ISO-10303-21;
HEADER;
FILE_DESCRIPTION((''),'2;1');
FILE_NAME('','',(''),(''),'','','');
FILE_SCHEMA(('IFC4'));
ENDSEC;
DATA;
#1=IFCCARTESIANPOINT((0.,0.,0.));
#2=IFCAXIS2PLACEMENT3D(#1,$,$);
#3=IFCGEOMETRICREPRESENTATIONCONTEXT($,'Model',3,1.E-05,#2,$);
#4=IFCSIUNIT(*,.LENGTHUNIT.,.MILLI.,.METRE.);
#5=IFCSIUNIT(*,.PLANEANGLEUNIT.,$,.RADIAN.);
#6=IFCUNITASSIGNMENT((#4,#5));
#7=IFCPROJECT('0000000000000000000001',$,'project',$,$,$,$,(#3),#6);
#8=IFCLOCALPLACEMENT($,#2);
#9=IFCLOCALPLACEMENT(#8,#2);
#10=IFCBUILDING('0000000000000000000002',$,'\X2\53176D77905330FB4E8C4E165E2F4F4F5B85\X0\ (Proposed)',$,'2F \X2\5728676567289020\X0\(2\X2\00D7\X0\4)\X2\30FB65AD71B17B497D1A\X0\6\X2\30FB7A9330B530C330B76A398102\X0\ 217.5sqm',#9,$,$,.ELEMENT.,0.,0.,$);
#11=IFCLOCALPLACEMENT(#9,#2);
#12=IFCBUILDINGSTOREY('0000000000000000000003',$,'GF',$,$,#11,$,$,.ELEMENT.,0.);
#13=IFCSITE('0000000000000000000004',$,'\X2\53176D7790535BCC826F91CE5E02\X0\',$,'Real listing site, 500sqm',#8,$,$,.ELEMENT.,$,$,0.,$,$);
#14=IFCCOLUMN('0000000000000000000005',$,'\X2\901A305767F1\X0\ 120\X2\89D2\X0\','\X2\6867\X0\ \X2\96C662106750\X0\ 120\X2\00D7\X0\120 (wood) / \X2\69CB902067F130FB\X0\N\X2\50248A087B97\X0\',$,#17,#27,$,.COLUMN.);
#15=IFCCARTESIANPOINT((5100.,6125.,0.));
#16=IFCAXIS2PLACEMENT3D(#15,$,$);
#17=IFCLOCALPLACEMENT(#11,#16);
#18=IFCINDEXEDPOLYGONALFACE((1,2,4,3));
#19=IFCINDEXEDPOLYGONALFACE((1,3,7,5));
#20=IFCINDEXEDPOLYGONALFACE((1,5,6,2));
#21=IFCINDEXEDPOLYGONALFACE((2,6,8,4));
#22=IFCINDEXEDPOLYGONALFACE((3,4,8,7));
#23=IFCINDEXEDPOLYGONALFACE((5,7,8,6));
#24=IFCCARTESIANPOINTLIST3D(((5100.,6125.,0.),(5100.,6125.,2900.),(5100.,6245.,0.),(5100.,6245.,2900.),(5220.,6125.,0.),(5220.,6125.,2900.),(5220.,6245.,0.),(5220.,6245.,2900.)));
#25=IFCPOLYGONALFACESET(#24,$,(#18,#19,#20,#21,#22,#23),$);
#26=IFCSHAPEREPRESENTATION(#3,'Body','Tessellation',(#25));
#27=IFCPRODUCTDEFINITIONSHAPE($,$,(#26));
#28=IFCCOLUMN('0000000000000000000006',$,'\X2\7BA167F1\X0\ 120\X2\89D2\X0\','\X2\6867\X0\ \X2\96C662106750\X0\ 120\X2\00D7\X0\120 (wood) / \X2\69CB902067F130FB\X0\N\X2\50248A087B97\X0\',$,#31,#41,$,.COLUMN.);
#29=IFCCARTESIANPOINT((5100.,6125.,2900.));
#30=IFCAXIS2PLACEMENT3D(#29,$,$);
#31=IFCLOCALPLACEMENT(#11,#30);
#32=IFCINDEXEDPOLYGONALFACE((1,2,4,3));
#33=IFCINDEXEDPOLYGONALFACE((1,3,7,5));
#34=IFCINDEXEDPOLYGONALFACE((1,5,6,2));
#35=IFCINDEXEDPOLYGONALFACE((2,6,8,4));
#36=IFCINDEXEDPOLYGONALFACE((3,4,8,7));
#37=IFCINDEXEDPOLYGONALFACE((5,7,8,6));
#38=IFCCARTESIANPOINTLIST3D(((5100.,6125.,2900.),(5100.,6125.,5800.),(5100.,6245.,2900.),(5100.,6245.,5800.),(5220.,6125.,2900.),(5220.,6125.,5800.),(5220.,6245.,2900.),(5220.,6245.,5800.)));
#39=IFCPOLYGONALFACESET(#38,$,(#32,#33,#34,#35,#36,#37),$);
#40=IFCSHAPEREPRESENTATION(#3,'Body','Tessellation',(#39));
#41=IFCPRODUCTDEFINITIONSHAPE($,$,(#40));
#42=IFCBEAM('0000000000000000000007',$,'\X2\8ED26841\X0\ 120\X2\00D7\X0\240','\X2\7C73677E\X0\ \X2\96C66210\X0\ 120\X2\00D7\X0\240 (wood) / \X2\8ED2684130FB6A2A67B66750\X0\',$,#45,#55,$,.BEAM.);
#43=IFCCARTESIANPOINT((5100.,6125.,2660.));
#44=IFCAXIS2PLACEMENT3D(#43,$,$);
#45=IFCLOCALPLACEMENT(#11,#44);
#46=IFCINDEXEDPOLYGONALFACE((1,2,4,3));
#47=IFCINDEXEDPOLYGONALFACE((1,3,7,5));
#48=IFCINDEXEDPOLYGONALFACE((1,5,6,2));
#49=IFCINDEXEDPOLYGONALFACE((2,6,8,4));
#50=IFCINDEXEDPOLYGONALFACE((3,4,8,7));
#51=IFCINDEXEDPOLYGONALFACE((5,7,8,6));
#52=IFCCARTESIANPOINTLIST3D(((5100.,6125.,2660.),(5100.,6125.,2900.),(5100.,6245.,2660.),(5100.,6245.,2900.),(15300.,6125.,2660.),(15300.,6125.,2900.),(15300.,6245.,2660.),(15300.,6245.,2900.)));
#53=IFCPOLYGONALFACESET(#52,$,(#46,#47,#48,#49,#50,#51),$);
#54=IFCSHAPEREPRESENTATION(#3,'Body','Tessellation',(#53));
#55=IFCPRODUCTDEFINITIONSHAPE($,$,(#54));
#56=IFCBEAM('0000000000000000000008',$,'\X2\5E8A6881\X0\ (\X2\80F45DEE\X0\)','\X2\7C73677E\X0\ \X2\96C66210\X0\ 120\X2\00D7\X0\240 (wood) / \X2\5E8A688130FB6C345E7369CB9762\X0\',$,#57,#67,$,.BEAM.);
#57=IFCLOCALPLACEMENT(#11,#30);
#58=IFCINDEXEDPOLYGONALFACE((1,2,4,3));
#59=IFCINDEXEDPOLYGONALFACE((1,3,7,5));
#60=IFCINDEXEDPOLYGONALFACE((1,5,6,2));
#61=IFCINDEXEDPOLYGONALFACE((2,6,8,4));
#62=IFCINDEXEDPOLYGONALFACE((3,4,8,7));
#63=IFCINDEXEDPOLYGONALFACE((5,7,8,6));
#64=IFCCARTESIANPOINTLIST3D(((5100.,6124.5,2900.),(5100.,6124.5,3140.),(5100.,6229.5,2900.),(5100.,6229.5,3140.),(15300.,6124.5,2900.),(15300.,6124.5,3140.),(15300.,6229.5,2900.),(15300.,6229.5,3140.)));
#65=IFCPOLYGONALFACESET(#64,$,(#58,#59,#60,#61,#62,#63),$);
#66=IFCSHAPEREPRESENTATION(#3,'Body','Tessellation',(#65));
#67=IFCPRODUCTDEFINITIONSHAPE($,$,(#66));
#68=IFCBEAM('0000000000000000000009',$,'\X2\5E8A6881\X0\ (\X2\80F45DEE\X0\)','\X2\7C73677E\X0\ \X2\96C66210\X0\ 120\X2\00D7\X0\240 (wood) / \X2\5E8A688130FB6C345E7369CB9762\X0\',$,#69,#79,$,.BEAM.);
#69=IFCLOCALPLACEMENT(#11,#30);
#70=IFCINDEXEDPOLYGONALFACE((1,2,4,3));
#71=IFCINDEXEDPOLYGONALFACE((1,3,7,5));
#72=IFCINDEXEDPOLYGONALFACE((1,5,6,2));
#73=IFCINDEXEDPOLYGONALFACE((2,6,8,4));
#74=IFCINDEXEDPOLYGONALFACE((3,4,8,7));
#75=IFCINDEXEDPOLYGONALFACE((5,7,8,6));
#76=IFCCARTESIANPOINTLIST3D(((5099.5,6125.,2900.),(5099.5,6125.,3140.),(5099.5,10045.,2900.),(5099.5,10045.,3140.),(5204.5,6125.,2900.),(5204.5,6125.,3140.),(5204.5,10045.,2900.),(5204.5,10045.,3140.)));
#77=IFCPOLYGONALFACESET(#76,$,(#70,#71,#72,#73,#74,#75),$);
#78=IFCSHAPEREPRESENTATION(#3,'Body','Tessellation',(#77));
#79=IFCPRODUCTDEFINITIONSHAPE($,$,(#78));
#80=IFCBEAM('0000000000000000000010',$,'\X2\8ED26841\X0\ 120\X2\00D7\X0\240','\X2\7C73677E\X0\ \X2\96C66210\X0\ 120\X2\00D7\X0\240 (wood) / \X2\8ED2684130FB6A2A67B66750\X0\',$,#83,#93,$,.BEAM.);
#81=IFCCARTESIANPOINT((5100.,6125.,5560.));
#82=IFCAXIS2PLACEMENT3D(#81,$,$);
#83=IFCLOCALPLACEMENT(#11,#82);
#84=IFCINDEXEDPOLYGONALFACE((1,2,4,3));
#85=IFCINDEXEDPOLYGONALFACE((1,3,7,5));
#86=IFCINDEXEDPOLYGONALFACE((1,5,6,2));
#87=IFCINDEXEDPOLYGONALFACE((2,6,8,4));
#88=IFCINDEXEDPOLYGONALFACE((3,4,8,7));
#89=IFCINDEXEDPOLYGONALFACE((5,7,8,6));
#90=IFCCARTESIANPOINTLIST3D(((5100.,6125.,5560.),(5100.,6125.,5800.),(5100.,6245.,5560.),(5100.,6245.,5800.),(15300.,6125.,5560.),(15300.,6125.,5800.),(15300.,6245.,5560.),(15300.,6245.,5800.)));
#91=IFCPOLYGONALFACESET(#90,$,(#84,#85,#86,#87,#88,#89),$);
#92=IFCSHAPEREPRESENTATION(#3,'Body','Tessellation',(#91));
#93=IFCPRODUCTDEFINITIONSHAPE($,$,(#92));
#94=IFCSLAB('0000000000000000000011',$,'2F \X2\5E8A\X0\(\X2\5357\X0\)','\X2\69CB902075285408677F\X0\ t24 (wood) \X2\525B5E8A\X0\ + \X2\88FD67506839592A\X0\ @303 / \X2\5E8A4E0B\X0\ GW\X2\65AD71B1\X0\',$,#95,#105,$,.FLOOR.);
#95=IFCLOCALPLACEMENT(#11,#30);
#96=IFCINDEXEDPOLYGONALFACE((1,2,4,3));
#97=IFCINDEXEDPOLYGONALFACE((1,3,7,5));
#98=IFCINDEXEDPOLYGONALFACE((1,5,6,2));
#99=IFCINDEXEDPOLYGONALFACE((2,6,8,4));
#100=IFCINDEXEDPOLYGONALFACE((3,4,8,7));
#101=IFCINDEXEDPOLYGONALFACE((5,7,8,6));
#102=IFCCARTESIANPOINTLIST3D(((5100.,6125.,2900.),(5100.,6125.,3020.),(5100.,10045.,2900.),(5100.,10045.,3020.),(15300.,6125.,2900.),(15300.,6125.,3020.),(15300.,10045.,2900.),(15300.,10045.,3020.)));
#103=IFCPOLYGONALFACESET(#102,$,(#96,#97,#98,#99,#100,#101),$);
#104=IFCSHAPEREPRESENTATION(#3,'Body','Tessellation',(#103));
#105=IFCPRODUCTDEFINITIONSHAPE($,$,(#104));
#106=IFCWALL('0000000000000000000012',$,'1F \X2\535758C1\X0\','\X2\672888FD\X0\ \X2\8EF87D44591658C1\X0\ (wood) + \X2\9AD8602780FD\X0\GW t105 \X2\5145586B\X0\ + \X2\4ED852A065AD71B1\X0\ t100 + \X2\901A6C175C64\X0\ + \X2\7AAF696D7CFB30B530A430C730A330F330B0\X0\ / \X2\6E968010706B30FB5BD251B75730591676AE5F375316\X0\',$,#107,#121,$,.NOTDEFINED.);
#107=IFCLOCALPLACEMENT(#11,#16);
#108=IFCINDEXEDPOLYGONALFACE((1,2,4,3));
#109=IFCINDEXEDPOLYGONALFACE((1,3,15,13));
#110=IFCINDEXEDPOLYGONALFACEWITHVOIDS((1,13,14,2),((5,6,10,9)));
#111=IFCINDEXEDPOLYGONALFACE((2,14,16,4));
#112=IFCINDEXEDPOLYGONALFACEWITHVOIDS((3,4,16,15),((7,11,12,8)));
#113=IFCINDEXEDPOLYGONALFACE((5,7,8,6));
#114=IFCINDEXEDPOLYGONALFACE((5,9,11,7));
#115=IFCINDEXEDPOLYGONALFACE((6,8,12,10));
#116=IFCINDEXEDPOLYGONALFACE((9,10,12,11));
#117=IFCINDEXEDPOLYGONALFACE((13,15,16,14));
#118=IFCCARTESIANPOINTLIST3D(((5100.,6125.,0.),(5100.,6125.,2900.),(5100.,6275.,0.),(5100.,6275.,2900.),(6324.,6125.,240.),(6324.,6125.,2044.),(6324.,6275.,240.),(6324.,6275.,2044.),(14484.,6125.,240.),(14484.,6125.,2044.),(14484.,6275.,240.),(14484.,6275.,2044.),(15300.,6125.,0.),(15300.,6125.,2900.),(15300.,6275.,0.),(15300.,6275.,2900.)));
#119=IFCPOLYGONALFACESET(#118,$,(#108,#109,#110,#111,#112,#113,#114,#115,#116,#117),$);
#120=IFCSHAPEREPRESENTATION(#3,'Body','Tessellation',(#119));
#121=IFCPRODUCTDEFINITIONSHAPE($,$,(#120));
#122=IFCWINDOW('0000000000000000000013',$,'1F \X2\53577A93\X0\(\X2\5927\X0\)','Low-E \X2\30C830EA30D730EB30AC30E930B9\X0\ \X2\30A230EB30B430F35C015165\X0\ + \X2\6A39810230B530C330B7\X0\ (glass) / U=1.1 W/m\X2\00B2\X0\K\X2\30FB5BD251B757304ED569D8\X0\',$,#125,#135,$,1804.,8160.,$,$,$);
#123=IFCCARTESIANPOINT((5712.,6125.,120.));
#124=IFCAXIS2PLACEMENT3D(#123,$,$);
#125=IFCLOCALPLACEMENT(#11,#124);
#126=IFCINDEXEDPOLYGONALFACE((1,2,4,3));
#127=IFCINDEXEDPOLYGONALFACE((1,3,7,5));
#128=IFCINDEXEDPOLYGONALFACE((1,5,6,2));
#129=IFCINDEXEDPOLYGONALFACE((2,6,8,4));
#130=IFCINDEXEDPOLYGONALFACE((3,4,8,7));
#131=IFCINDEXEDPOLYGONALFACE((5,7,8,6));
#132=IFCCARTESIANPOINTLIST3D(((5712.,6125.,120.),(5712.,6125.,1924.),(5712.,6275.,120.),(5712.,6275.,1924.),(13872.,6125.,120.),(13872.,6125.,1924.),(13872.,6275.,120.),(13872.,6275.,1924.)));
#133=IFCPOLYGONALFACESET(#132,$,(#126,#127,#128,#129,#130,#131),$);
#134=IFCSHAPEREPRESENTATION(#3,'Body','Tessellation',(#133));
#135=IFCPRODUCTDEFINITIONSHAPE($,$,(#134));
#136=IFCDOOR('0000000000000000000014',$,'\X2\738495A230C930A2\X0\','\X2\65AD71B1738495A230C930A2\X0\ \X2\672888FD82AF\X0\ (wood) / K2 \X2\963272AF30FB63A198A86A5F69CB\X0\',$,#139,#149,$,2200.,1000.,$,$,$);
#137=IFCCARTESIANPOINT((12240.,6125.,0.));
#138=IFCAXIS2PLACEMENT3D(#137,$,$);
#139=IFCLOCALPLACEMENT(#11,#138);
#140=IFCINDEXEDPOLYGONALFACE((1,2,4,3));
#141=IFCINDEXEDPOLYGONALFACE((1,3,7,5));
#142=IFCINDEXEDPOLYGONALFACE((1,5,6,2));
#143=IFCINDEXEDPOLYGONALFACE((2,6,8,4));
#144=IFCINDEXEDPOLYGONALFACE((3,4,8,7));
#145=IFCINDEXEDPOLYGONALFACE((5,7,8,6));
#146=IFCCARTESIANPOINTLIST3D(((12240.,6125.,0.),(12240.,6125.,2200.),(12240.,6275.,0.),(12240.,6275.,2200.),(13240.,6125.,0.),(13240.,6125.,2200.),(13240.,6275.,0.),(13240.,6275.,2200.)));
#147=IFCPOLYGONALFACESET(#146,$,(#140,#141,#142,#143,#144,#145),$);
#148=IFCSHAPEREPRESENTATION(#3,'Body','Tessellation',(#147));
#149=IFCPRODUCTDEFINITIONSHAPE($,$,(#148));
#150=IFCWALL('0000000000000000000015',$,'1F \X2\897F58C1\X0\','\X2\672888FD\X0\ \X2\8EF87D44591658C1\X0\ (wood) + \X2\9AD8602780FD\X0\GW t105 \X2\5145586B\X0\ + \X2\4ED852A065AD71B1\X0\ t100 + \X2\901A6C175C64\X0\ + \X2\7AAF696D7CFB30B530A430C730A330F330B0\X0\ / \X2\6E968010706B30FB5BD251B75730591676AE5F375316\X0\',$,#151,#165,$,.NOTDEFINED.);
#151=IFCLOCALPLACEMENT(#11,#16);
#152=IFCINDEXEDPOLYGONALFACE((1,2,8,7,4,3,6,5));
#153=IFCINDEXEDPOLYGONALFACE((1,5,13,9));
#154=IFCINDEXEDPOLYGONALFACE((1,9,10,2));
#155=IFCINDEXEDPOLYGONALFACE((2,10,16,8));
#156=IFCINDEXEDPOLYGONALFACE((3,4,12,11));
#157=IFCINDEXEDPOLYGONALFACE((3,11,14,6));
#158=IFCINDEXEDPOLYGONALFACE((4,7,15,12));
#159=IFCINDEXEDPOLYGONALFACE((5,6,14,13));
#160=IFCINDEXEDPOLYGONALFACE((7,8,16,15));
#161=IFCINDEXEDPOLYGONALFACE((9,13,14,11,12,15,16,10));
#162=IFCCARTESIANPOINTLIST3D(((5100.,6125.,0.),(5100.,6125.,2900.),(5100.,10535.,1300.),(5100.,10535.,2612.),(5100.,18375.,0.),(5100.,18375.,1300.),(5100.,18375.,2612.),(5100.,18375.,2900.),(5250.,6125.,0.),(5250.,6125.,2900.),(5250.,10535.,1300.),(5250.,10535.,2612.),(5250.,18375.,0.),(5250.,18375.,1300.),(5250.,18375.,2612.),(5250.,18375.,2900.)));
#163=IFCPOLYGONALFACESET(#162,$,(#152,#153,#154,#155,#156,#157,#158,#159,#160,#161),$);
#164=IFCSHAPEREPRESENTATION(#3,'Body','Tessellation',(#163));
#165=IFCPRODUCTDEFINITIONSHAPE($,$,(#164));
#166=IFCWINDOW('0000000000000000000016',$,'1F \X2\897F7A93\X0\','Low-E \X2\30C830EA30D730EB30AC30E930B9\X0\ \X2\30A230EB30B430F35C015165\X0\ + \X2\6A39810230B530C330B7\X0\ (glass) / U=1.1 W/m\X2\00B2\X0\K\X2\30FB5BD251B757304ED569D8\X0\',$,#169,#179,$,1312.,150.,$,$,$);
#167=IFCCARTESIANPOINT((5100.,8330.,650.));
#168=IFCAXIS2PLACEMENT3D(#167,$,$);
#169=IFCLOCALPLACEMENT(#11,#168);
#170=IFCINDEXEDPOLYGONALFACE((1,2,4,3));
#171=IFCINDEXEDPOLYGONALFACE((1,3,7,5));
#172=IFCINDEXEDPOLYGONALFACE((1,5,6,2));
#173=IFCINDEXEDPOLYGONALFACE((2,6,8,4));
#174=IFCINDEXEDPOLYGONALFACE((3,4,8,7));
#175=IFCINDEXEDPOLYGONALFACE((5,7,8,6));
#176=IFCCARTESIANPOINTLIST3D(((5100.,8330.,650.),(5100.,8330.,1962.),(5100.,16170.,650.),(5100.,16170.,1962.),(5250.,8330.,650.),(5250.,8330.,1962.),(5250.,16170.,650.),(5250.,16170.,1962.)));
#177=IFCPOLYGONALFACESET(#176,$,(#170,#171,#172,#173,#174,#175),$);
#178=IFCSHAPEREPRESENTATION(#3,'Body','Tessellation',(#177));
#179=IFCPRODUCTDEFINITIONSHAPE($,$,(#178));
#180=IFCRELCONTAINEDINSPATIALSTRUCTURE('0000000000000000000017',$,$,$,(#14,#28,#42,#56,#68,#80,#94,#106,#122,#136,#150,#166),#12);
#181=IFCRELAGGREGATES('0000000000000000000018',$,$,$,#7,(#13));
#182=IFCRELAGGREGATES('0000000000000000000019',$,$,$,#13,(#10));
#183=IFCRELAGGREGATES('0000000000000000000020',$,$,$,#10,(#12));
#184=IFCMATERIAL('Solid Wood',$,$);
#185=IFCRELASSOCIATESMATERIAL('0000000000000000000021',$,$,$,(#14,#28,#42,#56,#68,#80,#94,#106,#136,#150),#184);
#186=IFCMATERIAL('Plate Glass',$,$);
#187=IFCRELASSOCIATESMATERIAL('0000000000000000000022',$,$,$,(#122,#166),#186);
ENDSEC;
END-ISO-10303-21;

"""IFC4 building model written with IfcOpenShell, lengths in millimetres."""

from ifc_helpers import new_model, si_unit, frame, frame_2d, origin, place, context, project, spatial, rectangle, extrude, material, element, fill, save


model = new_model("IFC4")

# Units and contexts
model_context = context("Model", 3, precision=1e-05, world=origin())
ifc_project = project(units=[si_unit("LENGTHUNIT", "METRE", prefix="MILLI"), si_unit("PLANEANGLEUNIT", "RADIAN")], contexts=[model_context])

# Site, building, storey
site_placement = place(None, origin())
site = spatial("IfcSite", under=ifc_project, at=site_placement, Name="北海道富良野市", ObjectType="Real listing site, 500sqm", CompositionType="ELEMENT", RefElevation=0.0)
building_placement = place(site_placement, origin())
building = spatial("IfcBuilding", under=site, at=building_placement, Name="北海道・二世帯住宅 (Proposed)", ObjectType="2F 在来木造(2×4)・断熱等級6・窓サッシ樹脂 217.5sqm", CompositionType="ELEMENT", ElevationOfRefHeight=0.0, ElevationOfTerrain=0.0)
storey_placement = place(building_placement, origin())
storey = spatial("IfcBuildingStorey", under=building, at=storey_placement, Name="GF", CompositionType="ELEMENT", Elevation=0.0)

# Columns
ifc_material_1 = material(Name="Solid Wood")
column_1_placement = place(storey_placement, frame((5100.0, 6125.0, 0.0)))
element("IfcColumn", 1, at=column_1_placement, inside=storey, material=ifc_material_1, Name="通し柱 120角", Description="桧 集成材 120×120 (wood) / 構造柱・N値計算", PredefinedType="COLUMN", context=model_context, shape_type="SweptSolid", body=[
    extrude(rectangle(XDim=120.0, YDim=120.0, at=frame_2d((60.0, 60.0))), frame((5100.0, 6125.0, 0.0)), (0.0, 0.0, 1.0), 2900.0),
])
column_2_placement = place(storey_placement, frame((5100.0, 6125.0, 2900.0)))
element("IfcColumn", 2, at=column_2_placement, inside=storey, material=ifc_material_1, Name="管柱 120角", Description="桧 集成材 120×120 (wood) / 構造柱・N値計算", PredefinedType="COLUMN", context=model_context, shape_type="SweptSolid", body=[
    extrude(rectangle(XDim=120.0, YDim=120.0, at=frame_2d((60.0, 60.0))), frame((5100.0, 6125.0, 2900.0)), (0.0, 0.0, 1.0), 2900.0),
])

# Beams
beam_1_placement = place(storey_placement, frame((5100.0, 6125.0, 2660.0)))
element("IfcBeam", 3, at=beam_1_placement, inside=storey, material=ifc_material_1, Name="軒桁 120×240", Description="米松 集成 120×240 (wood) / 軒桁・横架材", PredefinedType="BEAM", context=model_context, shape_type="SweptSolid", body=[
    extrude(rectangle(XDim=10200.0, YDim=120.0, at=frame_2d((5100.0, 60.0))), frame((5100.0, 6125.0, 2660.0)), (0.0, 0.0, 1.0), 240.0),
])
beam_2_placement = place(storey_placement, frame((5100.0, 6125.0, 2900.0)))
element("IfcBeam", 4, at=beam_2_placement, inside=storey, material=ifc_material_1, Name="床梁 (胴差)", Description="米松 集成 120×240 (wood) / 床梁・水平構面", PredefinedType="BEAM", context=model_context, shape_type="SweptSolid", body=[
    extrude(rectangle(XDim=10200.0, YDim=105.0, at=frame_2d((5100.0, 52.0))), frame((5100.0, 6125.0, 2900.0)), (0.0, 0.0, 1.0), 240.0),
])
beam_3_placement = place(storey_placement, frame((5100.0, 6125.0, 2900.0)))
element("IfcBeam", 5, at=beam_3_placement, inside=storey, material=ifc_material_1, Name="床梁 (胴差)", Description="米松 集成 120×240 (wood) / 床梁・水平構面", PredefinedType="BEAM", context=model_context, shape_type="SweptSolid", body=[
    extrude(rectangle(XDim=105.0, YDim=3920.0, at=frame_2d((52.0, 1960.0))), frame((5100.0, 6125.0, 2900.0)), (0.0, 0.0, 1.0), 240.0),
])
beam_4_placement = place(storey_placement, frame((5100.0, 6125.0, 5560.0)))
element("IfcBeam", 6, at=beam_4_placement, inside=storey, material=ifc_material_1, Name="軒桁 120×240", Description="米松 集成 120×240 (wood) / 軒桁・横架材", PredefinedType="BEAM", context=model_context, shape_type="SweptSolid", body=[
    extrude(rectangle(XDim=10200.0, YDim=120.0, at=frame_2d((5100.0, 60.0))), frame((5100.0, 6125.0, 5560.0)), (0.0, 0.0, 1.0), 240.0),
])

# Slab
slab_1_placement = place(storey_placement, frame((5100.0, 6125.0, 2900.0)))
element("IfcSlab", 7, at=slab_1_placement, inside=storey, material=ifc_material_1, Name="2F 床(南)", Description="構造用合板 t24 (wood) 剛床 + 製材根太 @303 / 床下 GW断熱", PredefinedType="FLOOR", context=model_context, shape_type="SweptSolid", body=[
    extrude(rectangle(XDim=10200.0, YDim=3920.0, at=frame_2d((5100.0, 1960.0))), frame((5100.0, 6125.0, 2900.0)), (0.0, 0.0, 1.0), 120.0),
])

# Wall, openings, window, door
wall_1_placement = place(storey_placement, frame((5100.0, 6125.0, 0.0)))
wall_1 = element("IfcWall", 8, at=wall_1_placement, inside=storey, material=ifc_material_1, Name="1F 南壁", Description="木製 軸組外壁 (wood) + 高性能GW t105 充填 + 付加断熱 t100 + 通気層 + 窯業系サイディング / 準耐火・寒冷地外皮強化", PredefinedType="NOTDEFINED", context=model_context, shape_type="SweptSolid", body=[
    extrude(rectangle(XDim=10200.0, YDim=150.0, at=frame_2d((5100.0, 75.0))), frame((5100.0, 6125.0, 0.0)), (0.0, 0.0, 1.0), 2900.0),
])
opening_1_placement = place(storey_placement, frame((5712.0, 6125.0, 120.0)))
opening_1 = element("IfcOpeningElement", 9, at=opening_1_placement, cuts=wall_1, PredefinedType="NOTDEFINED", context=model_context, shape_type="SweptSolid", body=[
    extrude(rectangle(XDim=8160.0, YDim=150.0, at=frame_2d((4080.0, 75.0))), frame((5712.0, 6125.0, 120.0)), (0.0, 0.0, 1.0), 1804.0),
])
opening_2_placement = place(storey_placement, frame((12240.0, 6125.0, 0.0)))
opening_2 = element("IfcOpeningElement", 10, at=opening_2_placement, cuts=wall_1, PredefinedType="NOTDEFINED", context=model_context, shape_type="SweptSolid", body=[
    extrude(rectangle(XDim=1000.0, YDim=150.0, at=frame_2d((500.0, 75.0))), frame((12240.0, 6125.0, 0.0)), (0.0, 0.0, 1.0), 2200.0),
])
ifc_material_2 = material(Name="Plate Glass")
window_1_placement = place(storey_placement, frame((5712.0, 6125.0, 120.0)))
window_1 = element("IfcWindow", 11, at=window_1_placement, inside=storey, material=ifc_material_2, Name="1F 南窓(大)", Description="Low-E トリプルガラス アルゴン封入 + 樹脂サッシ (glass) / U=1.1 W/m²K・寒冷地仕様", OverallHeight=1804.0, OverallWidth=8160.0, context=model_context, shape_type="SweptSolid", body=[
    extrude(rectangle(XDim=8160.0, YDim=150.0, at=frame_2d((4080.0, 75.0))), frame((5712.0, 6125.0, 120.0)), (0.0, 0.0, 1.0), 1804.0),
])
fill(opening_1, window_1)
door_placement = place(storey_placement, frame((12240.0, 6125.0, 0.0)))
door = element("IfcDoor", 12, at=door_placement, inside=storey, material=ifc_material_1, Name="玄関ドア", Description="断熱玄関ドア 木製芯 (wood) / K2 防犯・採風機構", OverallHeight=2200.0, OverallWidth=1000.0, context=model_context, shape_type="SweptSolid", body=[
    extrude(rectangle(XDim=1000.0, YDim=150.0, at=frame_2d((500.0, 75.0))), frame((12240.0, 6125.0, 0.0)), (0.0, 0.0, 1.0), 2200.0),
])
fill(opening_2, door)

# Wall, opening, window
wall_2_placement = place(storey_placement, frame((5100.0, 6125.0, 0.0)))
wall_2 = element("IfcWall", 13, at=wall_2_placement, inside=storey, material=ifc_material_1, Name="1F 西壁", Description="木製 軸組外壁 (wood) + 高性能GW t105 充填 + 付加断熱 t100 + 通気層 + 窯業系サイディング / 準耐火・寒冷地外皮強化", PredefinedType="NOTDEFINED", context=model_context, shape_type="SweptSolid", body=[
    extrude(rectangle(XDim=150.0, YDim=12250.0, at=frame_2d((75.0, 6125.0))), frame((5100.0, 6125.0, 0.0)), (0.0, 0.0, 1.0), 2900.0),
])
opening_3_placement = place(storey_placement, frame((5100.0, 8330.0, 650.0)))
opening_3 = element("IfcOpeningElement", 14, at=opening_3_placement, cuts=wall_2, PredefinedType="NOTDEFINED", context=model_context, shape_type="SweptSolid", body=[
    extrude(rectangle(XDim=150.0, YDim=7840.0, at=frame_2d((75.0, 3920.0))), frame((5100.0, 8330.0, 650.0)), (0.0, 0.0, 1.0), 1312.0),
])
window_2_placement = place(storey_placement, frame((5100.0, 8330.0, 650.0)))
window_2 = element("IfcWindow", 15, at=window_2_placement, inside=storey, material=ifc_material_2, Name="1F 西窓", Description="Low-E トリプルガラス アルゴン封入 + 樹脂サッシ (glass) / U=1.1 W/m²K・寒冷地仕様", OverallHeight=1312.0, OverallWidth=150.0, context=model_context, shape_type="SweptSolid", body=[
    extrude(rectangle(XDim=150.0, YDim=7840.0, at=frame_2d((75.0, 3920.0))), frame((5100.0, 8330.0, 650.0)), (0.0, 0.0, 1.0), 1312.0),
])
fill(opening_3, window_2)

save(model, "model.ifc")
